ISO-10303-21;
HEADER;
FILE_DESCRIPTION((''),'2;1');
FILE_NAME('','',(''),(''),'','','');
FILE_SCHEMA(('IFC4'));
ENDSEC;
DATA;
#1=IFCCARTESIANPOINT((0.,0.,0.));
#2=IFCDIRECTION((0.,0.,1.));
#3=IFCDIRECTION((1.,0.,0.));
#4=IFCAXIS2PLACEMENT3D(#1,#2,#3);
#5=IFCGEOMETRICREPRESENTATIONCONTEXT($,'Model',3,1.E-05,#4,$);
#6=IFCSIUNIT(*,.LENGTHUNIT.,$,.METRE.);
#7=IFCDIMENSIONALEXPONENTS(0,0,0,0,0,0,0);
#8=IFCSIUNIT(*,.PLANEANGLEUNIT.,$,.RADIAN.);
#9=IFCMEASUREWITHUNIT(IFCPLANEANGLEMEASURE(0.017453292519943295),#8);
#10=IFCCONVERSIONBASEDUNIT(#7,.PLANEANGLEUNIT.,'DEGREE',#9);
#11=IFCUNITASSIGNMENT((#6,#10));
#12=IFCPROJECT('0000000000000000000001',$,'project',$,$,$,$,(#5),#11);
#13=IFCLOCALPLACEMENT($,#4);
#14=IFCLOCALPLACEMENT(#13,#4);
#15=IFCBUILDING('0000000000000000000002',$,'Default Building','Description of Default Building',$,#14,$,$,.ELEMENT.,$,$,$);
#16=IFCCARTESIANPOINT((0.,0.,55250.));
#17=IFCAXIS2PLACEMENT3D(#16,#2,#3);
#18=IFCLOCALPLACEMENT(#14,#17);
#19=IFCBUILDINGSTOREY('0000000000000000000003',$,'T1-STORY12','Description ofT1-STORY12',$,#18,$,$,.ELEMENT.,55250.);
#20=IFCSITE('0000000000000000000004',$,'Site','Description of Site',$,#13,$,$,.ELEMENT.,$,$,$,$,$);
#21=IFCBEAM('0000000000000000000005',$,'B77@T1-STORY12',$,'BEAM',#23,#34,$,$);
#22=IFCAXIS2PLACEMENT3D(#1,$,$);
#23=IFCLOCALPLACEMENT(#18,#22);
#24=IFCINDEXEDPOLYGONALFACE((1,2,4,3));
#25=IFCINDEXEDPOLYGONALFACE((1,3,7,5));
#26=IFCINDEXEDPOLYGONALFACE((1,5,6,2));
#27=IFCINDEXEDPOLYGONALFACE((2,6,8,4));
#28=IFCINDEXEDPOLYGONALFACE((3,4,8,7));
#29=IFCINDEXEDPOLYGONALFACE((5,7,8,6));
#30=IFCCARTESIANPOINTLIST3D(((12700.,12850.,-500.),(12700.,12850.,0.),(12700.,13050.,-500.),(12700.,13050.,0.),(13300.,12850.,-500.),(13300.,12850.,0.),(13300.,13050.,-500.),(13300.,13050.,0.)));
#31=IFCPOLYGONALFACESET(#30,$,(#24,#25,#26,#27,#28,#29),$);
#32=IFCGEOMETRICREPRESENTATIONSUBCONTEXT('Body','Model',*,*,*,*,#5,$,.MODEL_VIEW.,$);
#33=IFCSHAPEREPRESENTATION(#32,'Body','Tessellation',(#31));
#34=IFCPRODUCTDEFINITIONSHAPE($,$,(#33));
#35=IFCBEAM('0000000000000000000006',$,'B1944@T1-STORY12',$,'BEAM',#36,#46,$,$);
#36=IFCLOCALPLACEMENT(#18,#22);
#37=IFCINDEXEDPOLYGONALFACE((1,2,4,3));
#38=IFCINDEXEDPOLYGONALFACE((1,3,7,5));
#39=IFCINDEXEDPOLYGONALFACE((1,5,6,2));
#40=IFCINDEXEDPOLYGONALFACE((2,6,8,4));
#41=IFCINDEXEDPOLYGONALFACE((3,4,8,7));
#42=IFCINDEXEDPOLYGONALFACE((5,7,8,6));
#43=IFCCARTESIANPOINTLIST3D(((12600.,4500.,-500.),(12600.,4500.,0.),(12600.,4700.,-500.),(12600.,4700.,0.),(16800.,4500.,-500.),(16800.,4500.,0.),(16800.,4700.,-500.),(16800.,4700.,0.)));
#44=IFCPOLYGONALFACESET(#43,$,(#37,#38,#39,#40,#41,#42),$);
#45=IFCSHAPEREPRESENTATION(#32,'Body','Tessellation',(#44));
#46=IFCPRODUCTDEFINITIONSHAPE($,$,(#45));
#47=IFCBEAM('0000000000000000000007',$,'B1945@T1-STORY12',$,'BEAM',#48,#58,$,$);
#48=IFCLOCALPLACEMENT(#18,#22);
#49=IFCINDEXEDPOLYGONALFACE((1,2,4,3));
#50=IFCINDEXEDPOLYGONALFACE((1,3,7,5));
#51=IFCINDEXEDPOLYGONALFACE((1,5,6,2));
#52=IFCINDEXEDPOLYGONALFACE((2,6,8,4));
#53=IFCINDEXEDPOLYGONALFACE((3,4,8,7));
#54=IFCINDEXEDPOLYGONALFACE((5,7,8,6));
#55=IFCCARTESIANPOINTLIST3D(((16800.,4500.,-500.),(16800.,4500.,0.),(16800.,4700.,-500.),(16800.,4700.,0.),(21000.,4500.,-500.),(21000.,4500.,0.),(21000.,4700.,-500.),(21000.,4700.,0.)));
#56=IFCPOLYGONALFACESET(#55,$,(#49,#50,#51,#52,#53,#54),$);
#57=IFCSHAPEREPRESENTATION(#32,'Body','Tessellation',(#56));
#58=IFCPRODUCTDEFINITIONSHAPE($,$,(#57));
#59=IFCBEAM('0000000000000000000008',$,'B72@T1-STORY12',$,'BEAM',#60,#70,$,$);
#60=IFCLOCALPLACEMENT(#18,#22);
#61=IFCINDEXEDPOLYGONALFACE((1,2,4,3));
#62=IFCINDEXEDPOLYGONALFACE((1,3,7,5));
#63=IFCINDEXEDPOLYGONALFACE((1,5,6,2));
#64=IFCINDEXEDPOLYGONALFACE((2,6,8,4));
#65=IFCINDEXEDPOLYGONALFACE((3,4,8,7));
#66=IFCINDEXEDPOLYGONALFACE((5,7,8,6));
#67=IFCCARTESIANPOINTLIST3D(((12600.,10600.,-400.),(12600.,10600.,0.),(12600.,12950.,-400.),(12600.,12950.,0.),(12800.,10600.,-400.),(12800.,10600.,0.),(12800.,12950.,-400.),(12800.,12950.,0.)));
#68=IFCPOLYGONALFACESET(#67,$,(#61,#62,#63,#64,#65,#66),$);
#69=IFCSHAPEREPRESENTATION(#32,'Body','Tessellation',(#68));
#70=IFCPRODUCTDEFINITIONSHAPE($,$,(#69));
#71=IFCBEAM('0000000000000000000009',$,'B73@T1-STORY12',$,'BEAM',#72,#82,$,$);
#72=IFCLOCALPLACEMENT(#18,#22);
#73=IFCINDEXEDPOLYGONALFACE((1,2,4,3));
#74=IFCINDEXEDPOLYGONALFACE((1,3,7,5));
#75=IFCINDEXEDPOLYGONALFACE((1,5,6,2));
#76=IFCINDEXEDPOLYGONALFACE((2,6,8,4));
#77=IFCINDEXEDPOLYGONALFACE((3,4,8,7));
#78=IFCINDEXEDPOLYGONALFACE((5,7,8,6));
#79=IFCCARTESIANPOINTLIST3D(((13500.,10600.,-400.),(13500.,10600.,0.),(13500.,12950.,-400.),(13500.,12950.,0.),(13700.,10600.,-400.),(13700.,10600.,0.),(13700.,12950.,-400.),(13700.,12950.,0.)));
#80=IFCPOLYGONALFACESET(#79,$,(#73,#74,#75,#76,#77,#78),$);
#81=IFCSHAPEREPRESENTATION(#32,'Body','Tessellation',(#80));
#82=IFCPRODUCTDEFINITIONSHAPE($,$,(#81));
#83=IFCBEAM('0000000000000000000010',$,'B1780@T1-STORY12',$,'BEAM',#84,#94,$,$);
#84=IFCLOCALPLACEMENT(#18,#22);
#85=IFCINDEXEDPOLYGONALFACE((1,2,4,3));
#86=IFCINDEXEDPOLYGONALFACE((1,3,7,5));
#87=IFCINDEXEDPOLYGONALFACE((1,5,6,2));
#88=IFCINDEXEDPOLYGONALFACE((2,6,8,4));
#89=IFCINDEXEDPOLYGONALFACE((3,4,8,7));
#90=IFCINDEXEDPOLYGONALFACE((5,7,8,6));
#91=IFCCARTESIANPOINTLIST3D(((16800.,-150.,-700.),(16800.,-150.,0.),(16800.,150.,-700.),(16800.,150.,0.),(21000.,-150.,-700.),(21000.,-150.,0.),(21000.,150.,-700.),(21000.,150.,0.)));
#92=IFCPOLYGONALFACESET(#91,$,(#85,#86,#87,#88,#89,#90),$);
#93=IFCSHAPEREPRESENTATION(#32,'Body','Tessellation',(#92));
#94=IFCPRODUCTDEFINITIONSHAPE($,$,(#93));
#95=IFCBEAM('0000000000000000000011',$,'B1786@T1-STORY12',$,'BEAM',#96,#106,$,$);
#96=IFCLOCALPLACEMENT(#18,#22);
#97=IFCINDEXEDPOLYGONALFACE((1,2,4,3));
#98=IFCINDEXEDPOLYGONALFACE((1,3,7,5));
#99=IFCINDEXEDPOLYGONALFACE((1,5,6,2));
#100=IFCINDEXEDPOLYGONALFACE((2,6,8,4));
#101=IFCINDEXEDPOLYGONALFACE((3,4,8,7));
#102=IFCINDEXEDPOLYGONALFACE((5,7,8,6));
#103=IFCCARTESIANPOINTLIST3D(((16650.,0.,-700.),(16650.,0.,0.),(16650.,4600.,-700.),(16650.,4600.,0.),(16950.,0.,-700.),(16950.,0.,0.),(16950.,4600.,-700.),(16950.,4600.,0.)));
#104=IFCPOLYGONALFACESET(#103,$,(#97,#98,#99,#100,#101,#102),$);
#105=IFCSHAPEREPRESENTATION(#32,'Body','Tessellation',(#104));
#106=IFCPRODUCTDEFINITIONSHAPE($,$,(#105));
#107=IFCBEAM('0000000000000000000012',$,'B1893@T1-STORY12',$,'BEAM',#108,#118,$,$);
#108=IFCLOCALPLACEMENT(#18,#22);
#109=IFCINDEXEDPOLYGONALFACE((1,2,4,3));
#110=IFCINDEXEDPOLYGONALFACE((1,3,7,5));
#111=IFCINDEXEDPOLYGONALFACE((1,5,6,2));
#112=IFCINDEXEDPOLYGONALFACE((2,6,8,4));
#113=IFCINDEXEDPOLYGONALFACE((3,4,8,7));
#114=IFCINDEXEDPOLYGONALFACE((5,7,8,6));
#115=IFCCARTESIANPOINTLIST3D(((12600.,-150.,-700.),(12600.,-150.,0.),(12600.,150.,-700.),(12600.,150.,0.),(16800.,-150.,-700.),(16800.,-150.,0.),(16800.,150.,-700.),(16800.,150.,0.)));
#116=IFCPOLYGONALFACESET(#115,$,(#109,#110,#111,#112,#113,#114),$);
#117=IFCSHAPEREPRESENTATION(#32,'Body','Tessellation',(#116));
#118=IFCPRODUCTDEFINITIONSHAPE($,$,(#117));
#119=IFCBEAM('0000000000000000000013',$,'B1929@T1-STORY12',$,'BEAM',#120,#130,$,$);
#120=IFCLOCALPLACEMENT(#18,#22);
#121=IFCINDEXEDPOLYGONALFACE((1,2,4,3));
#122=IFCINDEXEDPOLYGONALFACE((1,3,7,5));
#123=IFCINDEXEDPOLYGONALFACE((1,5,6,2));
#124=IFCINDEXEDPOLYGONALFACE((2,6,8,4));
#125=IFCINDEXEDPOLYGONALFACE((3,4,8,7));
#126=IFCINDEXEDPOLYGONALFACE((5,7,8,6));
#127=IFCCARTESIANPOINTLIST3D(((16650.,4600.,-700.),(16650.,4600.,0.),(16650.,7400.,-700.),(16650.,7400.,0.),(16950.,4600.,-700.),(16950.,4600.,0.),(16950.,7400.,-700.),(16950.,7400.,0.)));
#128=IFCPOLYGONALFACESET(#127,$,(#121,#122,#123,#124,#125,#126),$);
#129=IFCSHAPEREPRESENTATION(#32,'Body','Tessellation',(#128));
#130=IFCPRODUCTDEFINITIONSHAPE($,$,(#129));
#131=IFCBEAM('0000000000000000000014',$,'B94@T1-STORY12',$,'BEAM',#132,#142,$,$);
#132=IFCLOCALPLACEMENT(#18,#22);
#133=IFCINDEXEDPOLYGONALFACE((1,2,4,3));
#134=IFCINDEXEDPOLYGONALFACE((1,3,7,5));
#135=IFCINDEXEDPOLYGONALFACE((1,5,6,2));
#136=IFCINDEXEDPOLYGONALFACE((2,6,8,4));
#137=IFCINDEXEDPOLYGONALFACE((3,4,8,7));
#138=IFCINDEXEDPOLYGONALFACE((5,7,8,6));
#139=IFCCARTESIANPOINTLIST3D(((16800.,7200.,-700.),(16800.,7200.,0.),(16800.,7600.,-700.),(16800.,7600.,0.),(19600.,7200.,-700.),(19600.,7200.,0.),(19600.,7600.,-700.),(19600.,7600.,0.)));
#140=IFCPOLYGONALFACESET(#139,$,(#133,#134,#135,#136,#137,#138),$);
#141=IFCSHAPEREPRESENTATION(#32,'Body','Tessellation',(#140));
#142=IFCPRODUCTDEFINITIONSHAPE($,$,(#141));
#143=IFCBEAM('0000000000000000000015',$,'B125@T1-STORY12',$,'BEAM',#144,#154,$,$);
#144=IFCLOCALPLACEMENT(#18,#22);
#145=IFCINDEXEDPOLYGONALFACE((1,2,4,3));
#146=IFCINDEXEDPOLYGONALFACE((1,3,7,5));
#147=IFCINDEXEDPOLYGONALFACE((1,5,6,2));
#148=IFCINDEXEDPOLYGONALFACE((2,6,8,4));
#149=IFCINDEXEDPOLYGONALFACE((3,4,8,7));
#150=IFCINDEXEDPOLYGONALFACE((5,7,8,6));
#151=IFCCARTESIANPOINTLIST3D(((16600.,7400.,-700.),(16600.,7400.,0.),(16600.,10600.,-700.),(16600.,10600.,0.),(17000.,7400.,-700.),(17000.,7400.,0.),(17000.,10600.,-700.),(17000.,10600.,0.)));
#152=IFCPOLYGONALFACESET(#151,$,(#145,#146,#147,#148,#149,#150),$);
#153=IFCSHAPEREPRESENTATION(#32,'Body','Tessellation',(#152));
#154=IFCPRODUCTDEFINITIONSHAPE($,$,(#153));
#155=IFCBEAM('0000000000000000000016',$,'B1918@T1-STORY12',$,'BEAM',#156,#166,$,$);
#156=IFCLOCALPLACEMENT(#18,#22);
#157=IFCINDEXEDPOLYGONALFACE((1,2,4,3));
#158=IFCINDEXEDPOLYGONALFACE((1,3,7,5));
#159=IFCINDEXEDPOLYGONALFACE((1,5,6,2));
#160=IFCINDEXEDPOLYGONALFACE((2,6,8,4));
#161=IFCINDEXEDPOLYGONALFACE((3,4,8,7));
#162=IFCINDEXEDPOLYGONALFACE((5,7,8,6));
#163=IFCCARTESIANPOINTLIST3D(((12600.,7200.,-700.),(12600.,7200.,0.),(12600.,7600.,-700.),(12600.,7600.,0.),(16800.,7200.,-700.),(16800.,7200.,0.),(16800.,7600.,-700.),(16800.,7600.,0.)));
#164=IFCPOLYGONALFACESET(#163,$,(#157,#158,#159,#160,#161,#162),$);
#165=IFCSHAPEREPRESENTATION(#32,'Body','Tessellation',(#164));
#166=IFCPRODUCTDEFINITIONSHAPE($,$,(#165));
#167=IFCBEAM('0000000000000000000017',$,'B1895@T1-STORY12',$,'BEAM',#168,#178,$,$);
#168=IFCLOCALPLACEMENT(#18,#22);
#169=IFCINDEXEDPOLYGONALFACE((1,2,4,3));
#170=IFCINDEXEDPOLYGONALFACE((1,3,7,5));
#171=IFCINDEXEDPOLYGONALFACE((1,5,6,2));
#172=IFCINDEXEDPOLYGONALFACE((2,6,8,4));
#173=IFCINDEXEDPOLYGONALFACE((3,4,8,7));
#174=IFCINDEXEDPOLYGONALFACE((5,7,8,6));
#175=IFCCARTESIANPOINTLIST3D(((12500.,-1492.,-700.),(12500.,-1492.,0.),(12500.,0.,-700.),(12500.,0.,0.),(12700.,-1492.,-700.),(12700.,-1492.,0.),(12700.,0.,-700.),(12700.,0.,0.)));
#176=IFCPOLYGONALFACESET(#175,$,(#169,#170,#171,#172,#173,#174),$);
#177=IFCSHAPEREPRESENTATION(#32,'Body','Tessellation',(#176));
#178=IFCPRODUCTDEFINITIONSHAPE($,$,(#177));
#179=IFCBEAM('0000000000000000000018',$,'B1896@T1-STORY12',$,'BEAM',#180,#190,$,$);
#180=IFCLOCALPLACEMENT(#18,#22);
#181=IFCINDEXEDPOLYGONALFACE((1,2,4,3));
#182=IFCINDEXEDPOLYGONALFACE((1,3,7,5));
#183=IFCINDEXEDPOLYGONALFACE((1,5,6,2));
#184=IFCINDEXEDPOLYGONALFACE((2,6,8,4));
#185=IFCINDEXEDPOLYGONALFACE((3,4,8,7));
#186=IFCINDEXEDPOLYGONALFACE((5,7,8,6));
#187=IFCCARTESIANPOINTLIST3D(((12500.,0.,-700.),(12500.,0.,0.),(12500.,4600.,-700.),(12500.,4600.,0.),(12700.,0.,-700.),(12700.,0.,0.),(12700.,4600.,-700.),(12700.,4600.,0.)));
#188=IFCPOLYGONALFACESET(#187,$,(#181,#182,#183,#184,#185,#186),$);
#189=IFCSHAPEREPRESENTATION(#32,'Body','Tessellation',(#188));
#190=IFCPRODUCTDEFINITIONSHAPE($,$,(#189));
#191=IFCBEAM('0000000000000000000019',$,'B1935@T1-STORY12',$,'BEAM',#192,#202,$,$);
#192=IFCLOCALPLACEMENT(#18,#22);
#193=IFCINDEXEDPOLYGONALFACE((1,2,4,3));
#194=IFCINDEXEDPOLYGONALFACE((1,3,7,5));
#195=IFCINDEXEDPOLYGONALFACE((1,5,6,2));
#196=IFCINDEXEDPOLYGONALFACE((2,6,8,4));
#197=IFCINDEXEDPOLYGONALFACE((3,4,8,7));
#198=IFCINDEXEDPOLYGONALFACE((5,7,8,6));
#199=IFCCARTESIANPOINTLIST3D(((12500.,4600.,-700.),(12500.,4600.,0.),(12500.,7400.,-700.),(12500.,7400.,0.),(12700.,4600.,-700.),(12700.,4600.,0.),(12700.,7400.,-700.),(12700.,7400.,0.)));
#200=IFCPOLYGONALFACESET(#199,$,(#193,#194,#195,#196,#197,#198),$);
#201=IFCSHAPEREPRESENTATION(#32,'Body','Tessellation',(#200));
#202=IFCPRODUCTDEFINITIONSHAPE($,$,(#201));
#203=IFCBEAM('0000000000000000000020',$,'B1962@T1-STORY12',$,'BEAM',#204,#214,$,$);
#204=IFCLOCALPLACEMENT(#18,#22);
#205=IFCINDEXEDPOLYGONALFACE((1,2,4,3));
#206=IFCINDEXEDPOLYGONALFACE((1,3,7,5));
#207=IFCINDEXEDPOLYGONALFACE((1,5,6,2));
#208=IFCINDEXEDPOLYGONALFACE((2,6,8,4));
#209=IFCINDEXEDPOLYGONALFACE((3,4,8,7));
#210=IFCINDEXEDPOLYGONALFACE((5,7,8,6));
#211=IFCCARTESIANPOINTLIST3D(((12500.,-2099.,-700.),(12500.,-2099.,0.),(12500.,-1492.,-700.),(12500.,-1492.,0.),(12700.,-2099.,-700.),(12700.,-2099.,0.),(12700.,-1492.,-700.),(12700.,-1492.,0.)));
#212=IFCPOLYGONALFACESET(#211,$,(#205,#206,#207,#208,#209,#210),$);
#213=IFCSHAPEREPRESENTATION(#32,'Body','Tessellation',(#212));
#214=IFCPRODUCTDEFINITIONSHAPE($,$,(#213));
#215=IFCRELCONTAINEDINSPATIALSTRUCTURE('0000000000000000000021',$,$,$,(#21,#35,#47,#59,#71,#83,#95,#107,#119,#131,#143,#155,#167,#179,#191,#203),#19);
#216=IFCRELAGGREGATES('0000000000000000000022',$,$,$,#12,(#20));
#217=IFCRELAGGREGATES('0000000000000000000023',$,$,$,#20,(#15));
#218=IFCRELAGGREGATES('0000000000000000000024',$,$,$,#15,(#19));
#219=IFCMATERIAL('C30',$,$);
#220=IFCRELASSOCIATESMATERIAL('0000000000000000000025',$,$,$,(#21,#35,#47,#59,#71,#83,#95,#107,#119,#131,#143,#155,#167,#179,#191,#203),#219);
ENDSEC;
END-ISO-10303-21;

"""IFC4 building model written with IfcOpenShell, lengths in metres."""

from ifc_helpers import new_model, entity, si_unit, converted_unit, frame, origin_with_axes, place, context, subcontext, project, spatial, rectangle, extrude, material, element, save


model = new_model("IFC4")

# Units and contexts
model_context = context("Model", 3, precision=1e-05, world=origin_with_axes())
body_context = subcontext(model_context, "Body", "Model", "MODEL_VIEW")
ifc_project = project(units=[si_unit("LENGTHUNIT", "METRE"), converted_unit("PLANEANGLEUNIT", "DEGREE", entity("IfcPlaneAngleMeasure", 0.017453292519943295), si_unit("PLANEANGLEUNIT", "RADIAN"), dimensions=[0, 0, 0, 0, 0, 0, 0])], contexts=[model_context])

# Site, building, storey
site_placement = place(None, origin_with_axes())
site = spatial("IfcSite", under=ifc_project, at=site_placement, Name="Site", Description="Description of Site", CompositionType="ELEMENT")
building_placement = place(site_placement, origin_with_axes())
building = spatial("IfcBuilding", under=site, at=building_placement, Name="Default Building", Description="Description of Default Building", CompositionType="ELEMENT")
storey_placement = place(building_placement, frame((0.0, 0.0, 55250.0), z_axis=(0.0, 0.0, 1.0), x_axis=(1.0, 0.0, 0.0)))
storey = spatial("IfcBuildingStorey", under=building, at=storey_placement, Name="T1-STORY12", Description="Description ofT1-STORY12", CompositionType="ELEMENT", Elevation=55250.0)

# Beams
ifc_material_1 = material(Name="C30")
beam_1_placement = place(storey_placement, frame((12700.0, 12950.0, -250.0), z_axis=(1.0, 0.0, 0.0), x_axis=(0.0, 1.0, 0.0)))
element("IfcBeam", 1, at=beam_1_placement, inside=storey, material=ifc_material_1, Name="B77@T1-STORY12", ObjectType="BEAM", context=body_context, shape_type="SweptSolid", body=[
    extrude(rectangle(XDim=200.0, YDim=500.0), origin_with_axes(), (0.0, 0.0, 1.0), 600.0),
])
for number, where, z_axis, x_axis, name in (
    (2, (12600.0, 4600.0, -250.0), (1.0, 0.0, 0.0), (0.0, 1.0, 0.0), "B1944@T1-STORY12"),
    (3, (16800.0, 4600.0, -250.0), (1.0, 0.0, 0.0), (0.0, 1.0, 0.0), "B1945@T1-STORY12"),
):
    element("IfcBeam", number, at=place(storey_placement, frame(where, z_axis=z_axis, x_axis=x_axis)), inside=storey, material=ifc_material_1, Name=name, ObjectType="BEAM", context=body_context, shape_type="SweptSolid", body=[
        extrude(rectangle(XDim=200.0, YDim=500.0), origin_with_axes(), (0.0, 0.0, 1.0), 4200.0),
    ])
for number, where, z_axis, x_axis, name in (
    (4, (12700.0, 10600.0, -200.0), (0.0, 1.0, 0.0), (-1.0, 0.0, 0.0), "B72@T1-STORY12"),
    (5, (13600.0, 10600.0, -200.0), (0.0, 1.0, 0.0), (-1.0, 0.0, 0.0), "B73@T1-STORY12"),
):
    element("IfcBeam", number, at=place(storey_placement, frame(where, z_axis=z_axis, x_axis=x_axis)), inside=storey, material=ifc_material_1, Name=name, ObjectType="BEAM", context=body_context, shape_type="SweptSolid", body=[
        extrude(rectangle(XDim=200.0, YDim=400.0), origin_with_axes(), (0.0, 0.0, 1.0), 2350.0),
    ])
beam_2_placement = place(storey_placement, frame((16800.0, 0.0, -350.0), z_axis=(1.0, 0.0, 0.0), x_axis=(0.0, 1.0, 0.0)))
element("IfcBeam", 6, at=beam_2_placement, inside=storey, material=ifc_material_1, Name="B1780@T1-STORY12", ObjectType="BEAM", context=body_context, shape_type="SweptSolid", body=[
    extrude(rectangle(XDim=300.0, YDim=700.0), origin_with_axes(), (0.0, 0.0, 1.0), 4200.0),
])
beam_3_placement = place(storey_placement, frame((16800.0, 0.0, -350.0), z_axis=(0.0, 1.0, 0.0), x_axis=(-1.0, 0.0, 0.0)))
element("IfcBeam", 7, at=beam_3_placement, inside=storey, material=ifc_material_1, Name="B1786@T1-STORY12", ObjectType="BEAM", context=body_context, shape_type="SweptSolid", body=[
    extrude(rectangle(XDim=300.0, YDim=700.0), origin_with_axes(), (0.0, 0.0, 1.0), 4600.0),
])
beam_4_placement = place(storey_placement, frame((12600.0, 0.0, -350.0), z_axis=(1.0, 0.0, 0.0), x_axis=(0.0, 1.0, 0.0)))
element("IfcBeam", 8, at=beam_4_placement, inside=storey, material=ifc_material_1, Name="B1893@T1-STORY12", ObjectType="BEAM", context=body_context, shape_type="SweptSolid", body=[
    extrude(rectangle(XDim=300.0, YDim=700.0), origin_with_axes(), (0.0, 0.0, 1.0), 4200.0),
])
beam_5_placement = place(storey_placement, frame((16800.0, 4600.0, -350.0), z_axis=(0.0, 1.0, 0.0), x_axis=(-1.0, 0.0, 0.0)))
element("IfcBeam", 9, at=beam_5_placement, inside=storey, material=ifc_material_1, Name="B1929@T1-STORY12", ObjectType="BEAM", context=body_context, shape_type="SweptSolid", body=[
    extrude(rectangle(XDim=300.0, YDim=700.0), origin_with_axes(), (0.0, 0.0, 1.0), 2800.0),
])
beam_6_placement = place(storey_placement, frame((16800.0, 7400.0, -350.0), z_axis=(1.0, 0.0, 0.0), x_axis=(0.0, 1.0, 0.0)))
element("IfcBeam", 10, at=beam_6_placement, inside=storey, material=ifc_material_1, Name="B94@T1-STORY12", ObjectType="BEAM", context=body_context, shape_type="SweptSolid", body=[
    extrude(rectangle(XDim=400.0, YDim=700.0), origin_with_axes(), (0.0, 0.0, 1.0), 2800.0),
])
beam_7_placement = place(storey_placement, frame((16800.0, 10600.0, -350.0), z_axis=(0.0, -1.0, 0.0), x_axis=(1.0, 0.0, 0.0)))
element("IfcBeam", 11, at=beam_7_placement, inside=storey, material=ifc_material_1, Name="B125@T1-STORY12", ObjectType="BEAM", context=body_context, shape_type="SweptSolid", body=[
    extrude(rectangle(XDim=400.0, YDim=700.0), origin_with_axes(), (0.0, 0.0, 1.0), 3200.0),
])
beam_8_placement = place(storey_placement, frame((12600.0, 7400.0, -350.0), z_axis=(1.0, 0.0, 0.0), x_axis=(0.0, 1.0, 0.0)))
element("IfcBeam", 12, at=beam_8_placement, inside=storey, material=ifc_material_1, Name="B1918@T1-STORY12", ObjectType="BEAM", context=body_context, shape_type="SweptSolid", body=[
    extrude(rectangle(XDim=400.0, YDim=700.0), origin_with_axes(), (0.0, 0.0, 1.0), 4200.0),
])
beam_9_placement = place(storey_placement, frame((12600.0, -1492.0, -350.0), z_axis=(0.0, 1.0, 0.0), x_axis=(-1.0, 0.0, 0.0)))
element("IfcBeam", 13, at=beam_9_placement, inside=storey, material=ifc_material_1, Name="B1895@T1-STORY12", ObjectType="BEAM", context=body_context, shape_type="SweptSolid", body=[
    extrude(rectangle(XDim=200.0, YDim=700.0), origin_with_axes(), (0.0, 0.0, 1.0), 1492.0),
])
beam_10_placement = place(storey_placement, frame((12600.0, 0.0, -350.0), z_axis=(0.0, 1.0, 0.0), x_axis=(-1.0, 0.0, 0.0)))
element("IfcBeam", 14, at=beam_10_placement, inside=storey, material=ifc_material_1, Name="B1896@T1-STORY12", ObjectType="BEAM", context=body_context, shape_type="SweptSolid", body=[
    extrude(rectangle(XDim=200.0, YDim=700.0), origin_with_axes(), (0.0, 0.0, 1.0), 4600.0),
])
beam_11_placement = place(storey_placement, frame((12600.0, 4600.0, -350.0), z_axis=(0.0, 1.0, 0.0), x_axis=(-1.0, 0.0, 0.0)))
element("IfcBeam", 15, at=beam_11_placement, inside=storey, material=ifc_material_1, Name="B1935@T1-STORY12", ObjectType="BEAM", context=body_context, shape_type="SweptSolid", body=[
    extrude(rectangle(XDim=200.0, YDim=700.0), origin_with_axes(), (0.0, 0.0, 1.0), 2800.0),
])
beam_12_placement = place(storey_placement, frame((12600.0, -2099.0, -350.0), z_axis=(0.0, 1.0, 0.0), x_axis=(-1.0, 0.0, 0.0)))
element("IfcBeam", 16, at=beam_12_placement, inside=storey, material=ifc_material_1, Name="B1962@T1-STORY12", ObjectType="BEAM", context=body_context, shape_type="SweptSolid", body=[
    extrude(rectangle(XDim=200.0, YDim=700.0), origin_with_axes(), (0.0, 0.0, 1.0), 607.0),
])

save(model, "model.ifc")
